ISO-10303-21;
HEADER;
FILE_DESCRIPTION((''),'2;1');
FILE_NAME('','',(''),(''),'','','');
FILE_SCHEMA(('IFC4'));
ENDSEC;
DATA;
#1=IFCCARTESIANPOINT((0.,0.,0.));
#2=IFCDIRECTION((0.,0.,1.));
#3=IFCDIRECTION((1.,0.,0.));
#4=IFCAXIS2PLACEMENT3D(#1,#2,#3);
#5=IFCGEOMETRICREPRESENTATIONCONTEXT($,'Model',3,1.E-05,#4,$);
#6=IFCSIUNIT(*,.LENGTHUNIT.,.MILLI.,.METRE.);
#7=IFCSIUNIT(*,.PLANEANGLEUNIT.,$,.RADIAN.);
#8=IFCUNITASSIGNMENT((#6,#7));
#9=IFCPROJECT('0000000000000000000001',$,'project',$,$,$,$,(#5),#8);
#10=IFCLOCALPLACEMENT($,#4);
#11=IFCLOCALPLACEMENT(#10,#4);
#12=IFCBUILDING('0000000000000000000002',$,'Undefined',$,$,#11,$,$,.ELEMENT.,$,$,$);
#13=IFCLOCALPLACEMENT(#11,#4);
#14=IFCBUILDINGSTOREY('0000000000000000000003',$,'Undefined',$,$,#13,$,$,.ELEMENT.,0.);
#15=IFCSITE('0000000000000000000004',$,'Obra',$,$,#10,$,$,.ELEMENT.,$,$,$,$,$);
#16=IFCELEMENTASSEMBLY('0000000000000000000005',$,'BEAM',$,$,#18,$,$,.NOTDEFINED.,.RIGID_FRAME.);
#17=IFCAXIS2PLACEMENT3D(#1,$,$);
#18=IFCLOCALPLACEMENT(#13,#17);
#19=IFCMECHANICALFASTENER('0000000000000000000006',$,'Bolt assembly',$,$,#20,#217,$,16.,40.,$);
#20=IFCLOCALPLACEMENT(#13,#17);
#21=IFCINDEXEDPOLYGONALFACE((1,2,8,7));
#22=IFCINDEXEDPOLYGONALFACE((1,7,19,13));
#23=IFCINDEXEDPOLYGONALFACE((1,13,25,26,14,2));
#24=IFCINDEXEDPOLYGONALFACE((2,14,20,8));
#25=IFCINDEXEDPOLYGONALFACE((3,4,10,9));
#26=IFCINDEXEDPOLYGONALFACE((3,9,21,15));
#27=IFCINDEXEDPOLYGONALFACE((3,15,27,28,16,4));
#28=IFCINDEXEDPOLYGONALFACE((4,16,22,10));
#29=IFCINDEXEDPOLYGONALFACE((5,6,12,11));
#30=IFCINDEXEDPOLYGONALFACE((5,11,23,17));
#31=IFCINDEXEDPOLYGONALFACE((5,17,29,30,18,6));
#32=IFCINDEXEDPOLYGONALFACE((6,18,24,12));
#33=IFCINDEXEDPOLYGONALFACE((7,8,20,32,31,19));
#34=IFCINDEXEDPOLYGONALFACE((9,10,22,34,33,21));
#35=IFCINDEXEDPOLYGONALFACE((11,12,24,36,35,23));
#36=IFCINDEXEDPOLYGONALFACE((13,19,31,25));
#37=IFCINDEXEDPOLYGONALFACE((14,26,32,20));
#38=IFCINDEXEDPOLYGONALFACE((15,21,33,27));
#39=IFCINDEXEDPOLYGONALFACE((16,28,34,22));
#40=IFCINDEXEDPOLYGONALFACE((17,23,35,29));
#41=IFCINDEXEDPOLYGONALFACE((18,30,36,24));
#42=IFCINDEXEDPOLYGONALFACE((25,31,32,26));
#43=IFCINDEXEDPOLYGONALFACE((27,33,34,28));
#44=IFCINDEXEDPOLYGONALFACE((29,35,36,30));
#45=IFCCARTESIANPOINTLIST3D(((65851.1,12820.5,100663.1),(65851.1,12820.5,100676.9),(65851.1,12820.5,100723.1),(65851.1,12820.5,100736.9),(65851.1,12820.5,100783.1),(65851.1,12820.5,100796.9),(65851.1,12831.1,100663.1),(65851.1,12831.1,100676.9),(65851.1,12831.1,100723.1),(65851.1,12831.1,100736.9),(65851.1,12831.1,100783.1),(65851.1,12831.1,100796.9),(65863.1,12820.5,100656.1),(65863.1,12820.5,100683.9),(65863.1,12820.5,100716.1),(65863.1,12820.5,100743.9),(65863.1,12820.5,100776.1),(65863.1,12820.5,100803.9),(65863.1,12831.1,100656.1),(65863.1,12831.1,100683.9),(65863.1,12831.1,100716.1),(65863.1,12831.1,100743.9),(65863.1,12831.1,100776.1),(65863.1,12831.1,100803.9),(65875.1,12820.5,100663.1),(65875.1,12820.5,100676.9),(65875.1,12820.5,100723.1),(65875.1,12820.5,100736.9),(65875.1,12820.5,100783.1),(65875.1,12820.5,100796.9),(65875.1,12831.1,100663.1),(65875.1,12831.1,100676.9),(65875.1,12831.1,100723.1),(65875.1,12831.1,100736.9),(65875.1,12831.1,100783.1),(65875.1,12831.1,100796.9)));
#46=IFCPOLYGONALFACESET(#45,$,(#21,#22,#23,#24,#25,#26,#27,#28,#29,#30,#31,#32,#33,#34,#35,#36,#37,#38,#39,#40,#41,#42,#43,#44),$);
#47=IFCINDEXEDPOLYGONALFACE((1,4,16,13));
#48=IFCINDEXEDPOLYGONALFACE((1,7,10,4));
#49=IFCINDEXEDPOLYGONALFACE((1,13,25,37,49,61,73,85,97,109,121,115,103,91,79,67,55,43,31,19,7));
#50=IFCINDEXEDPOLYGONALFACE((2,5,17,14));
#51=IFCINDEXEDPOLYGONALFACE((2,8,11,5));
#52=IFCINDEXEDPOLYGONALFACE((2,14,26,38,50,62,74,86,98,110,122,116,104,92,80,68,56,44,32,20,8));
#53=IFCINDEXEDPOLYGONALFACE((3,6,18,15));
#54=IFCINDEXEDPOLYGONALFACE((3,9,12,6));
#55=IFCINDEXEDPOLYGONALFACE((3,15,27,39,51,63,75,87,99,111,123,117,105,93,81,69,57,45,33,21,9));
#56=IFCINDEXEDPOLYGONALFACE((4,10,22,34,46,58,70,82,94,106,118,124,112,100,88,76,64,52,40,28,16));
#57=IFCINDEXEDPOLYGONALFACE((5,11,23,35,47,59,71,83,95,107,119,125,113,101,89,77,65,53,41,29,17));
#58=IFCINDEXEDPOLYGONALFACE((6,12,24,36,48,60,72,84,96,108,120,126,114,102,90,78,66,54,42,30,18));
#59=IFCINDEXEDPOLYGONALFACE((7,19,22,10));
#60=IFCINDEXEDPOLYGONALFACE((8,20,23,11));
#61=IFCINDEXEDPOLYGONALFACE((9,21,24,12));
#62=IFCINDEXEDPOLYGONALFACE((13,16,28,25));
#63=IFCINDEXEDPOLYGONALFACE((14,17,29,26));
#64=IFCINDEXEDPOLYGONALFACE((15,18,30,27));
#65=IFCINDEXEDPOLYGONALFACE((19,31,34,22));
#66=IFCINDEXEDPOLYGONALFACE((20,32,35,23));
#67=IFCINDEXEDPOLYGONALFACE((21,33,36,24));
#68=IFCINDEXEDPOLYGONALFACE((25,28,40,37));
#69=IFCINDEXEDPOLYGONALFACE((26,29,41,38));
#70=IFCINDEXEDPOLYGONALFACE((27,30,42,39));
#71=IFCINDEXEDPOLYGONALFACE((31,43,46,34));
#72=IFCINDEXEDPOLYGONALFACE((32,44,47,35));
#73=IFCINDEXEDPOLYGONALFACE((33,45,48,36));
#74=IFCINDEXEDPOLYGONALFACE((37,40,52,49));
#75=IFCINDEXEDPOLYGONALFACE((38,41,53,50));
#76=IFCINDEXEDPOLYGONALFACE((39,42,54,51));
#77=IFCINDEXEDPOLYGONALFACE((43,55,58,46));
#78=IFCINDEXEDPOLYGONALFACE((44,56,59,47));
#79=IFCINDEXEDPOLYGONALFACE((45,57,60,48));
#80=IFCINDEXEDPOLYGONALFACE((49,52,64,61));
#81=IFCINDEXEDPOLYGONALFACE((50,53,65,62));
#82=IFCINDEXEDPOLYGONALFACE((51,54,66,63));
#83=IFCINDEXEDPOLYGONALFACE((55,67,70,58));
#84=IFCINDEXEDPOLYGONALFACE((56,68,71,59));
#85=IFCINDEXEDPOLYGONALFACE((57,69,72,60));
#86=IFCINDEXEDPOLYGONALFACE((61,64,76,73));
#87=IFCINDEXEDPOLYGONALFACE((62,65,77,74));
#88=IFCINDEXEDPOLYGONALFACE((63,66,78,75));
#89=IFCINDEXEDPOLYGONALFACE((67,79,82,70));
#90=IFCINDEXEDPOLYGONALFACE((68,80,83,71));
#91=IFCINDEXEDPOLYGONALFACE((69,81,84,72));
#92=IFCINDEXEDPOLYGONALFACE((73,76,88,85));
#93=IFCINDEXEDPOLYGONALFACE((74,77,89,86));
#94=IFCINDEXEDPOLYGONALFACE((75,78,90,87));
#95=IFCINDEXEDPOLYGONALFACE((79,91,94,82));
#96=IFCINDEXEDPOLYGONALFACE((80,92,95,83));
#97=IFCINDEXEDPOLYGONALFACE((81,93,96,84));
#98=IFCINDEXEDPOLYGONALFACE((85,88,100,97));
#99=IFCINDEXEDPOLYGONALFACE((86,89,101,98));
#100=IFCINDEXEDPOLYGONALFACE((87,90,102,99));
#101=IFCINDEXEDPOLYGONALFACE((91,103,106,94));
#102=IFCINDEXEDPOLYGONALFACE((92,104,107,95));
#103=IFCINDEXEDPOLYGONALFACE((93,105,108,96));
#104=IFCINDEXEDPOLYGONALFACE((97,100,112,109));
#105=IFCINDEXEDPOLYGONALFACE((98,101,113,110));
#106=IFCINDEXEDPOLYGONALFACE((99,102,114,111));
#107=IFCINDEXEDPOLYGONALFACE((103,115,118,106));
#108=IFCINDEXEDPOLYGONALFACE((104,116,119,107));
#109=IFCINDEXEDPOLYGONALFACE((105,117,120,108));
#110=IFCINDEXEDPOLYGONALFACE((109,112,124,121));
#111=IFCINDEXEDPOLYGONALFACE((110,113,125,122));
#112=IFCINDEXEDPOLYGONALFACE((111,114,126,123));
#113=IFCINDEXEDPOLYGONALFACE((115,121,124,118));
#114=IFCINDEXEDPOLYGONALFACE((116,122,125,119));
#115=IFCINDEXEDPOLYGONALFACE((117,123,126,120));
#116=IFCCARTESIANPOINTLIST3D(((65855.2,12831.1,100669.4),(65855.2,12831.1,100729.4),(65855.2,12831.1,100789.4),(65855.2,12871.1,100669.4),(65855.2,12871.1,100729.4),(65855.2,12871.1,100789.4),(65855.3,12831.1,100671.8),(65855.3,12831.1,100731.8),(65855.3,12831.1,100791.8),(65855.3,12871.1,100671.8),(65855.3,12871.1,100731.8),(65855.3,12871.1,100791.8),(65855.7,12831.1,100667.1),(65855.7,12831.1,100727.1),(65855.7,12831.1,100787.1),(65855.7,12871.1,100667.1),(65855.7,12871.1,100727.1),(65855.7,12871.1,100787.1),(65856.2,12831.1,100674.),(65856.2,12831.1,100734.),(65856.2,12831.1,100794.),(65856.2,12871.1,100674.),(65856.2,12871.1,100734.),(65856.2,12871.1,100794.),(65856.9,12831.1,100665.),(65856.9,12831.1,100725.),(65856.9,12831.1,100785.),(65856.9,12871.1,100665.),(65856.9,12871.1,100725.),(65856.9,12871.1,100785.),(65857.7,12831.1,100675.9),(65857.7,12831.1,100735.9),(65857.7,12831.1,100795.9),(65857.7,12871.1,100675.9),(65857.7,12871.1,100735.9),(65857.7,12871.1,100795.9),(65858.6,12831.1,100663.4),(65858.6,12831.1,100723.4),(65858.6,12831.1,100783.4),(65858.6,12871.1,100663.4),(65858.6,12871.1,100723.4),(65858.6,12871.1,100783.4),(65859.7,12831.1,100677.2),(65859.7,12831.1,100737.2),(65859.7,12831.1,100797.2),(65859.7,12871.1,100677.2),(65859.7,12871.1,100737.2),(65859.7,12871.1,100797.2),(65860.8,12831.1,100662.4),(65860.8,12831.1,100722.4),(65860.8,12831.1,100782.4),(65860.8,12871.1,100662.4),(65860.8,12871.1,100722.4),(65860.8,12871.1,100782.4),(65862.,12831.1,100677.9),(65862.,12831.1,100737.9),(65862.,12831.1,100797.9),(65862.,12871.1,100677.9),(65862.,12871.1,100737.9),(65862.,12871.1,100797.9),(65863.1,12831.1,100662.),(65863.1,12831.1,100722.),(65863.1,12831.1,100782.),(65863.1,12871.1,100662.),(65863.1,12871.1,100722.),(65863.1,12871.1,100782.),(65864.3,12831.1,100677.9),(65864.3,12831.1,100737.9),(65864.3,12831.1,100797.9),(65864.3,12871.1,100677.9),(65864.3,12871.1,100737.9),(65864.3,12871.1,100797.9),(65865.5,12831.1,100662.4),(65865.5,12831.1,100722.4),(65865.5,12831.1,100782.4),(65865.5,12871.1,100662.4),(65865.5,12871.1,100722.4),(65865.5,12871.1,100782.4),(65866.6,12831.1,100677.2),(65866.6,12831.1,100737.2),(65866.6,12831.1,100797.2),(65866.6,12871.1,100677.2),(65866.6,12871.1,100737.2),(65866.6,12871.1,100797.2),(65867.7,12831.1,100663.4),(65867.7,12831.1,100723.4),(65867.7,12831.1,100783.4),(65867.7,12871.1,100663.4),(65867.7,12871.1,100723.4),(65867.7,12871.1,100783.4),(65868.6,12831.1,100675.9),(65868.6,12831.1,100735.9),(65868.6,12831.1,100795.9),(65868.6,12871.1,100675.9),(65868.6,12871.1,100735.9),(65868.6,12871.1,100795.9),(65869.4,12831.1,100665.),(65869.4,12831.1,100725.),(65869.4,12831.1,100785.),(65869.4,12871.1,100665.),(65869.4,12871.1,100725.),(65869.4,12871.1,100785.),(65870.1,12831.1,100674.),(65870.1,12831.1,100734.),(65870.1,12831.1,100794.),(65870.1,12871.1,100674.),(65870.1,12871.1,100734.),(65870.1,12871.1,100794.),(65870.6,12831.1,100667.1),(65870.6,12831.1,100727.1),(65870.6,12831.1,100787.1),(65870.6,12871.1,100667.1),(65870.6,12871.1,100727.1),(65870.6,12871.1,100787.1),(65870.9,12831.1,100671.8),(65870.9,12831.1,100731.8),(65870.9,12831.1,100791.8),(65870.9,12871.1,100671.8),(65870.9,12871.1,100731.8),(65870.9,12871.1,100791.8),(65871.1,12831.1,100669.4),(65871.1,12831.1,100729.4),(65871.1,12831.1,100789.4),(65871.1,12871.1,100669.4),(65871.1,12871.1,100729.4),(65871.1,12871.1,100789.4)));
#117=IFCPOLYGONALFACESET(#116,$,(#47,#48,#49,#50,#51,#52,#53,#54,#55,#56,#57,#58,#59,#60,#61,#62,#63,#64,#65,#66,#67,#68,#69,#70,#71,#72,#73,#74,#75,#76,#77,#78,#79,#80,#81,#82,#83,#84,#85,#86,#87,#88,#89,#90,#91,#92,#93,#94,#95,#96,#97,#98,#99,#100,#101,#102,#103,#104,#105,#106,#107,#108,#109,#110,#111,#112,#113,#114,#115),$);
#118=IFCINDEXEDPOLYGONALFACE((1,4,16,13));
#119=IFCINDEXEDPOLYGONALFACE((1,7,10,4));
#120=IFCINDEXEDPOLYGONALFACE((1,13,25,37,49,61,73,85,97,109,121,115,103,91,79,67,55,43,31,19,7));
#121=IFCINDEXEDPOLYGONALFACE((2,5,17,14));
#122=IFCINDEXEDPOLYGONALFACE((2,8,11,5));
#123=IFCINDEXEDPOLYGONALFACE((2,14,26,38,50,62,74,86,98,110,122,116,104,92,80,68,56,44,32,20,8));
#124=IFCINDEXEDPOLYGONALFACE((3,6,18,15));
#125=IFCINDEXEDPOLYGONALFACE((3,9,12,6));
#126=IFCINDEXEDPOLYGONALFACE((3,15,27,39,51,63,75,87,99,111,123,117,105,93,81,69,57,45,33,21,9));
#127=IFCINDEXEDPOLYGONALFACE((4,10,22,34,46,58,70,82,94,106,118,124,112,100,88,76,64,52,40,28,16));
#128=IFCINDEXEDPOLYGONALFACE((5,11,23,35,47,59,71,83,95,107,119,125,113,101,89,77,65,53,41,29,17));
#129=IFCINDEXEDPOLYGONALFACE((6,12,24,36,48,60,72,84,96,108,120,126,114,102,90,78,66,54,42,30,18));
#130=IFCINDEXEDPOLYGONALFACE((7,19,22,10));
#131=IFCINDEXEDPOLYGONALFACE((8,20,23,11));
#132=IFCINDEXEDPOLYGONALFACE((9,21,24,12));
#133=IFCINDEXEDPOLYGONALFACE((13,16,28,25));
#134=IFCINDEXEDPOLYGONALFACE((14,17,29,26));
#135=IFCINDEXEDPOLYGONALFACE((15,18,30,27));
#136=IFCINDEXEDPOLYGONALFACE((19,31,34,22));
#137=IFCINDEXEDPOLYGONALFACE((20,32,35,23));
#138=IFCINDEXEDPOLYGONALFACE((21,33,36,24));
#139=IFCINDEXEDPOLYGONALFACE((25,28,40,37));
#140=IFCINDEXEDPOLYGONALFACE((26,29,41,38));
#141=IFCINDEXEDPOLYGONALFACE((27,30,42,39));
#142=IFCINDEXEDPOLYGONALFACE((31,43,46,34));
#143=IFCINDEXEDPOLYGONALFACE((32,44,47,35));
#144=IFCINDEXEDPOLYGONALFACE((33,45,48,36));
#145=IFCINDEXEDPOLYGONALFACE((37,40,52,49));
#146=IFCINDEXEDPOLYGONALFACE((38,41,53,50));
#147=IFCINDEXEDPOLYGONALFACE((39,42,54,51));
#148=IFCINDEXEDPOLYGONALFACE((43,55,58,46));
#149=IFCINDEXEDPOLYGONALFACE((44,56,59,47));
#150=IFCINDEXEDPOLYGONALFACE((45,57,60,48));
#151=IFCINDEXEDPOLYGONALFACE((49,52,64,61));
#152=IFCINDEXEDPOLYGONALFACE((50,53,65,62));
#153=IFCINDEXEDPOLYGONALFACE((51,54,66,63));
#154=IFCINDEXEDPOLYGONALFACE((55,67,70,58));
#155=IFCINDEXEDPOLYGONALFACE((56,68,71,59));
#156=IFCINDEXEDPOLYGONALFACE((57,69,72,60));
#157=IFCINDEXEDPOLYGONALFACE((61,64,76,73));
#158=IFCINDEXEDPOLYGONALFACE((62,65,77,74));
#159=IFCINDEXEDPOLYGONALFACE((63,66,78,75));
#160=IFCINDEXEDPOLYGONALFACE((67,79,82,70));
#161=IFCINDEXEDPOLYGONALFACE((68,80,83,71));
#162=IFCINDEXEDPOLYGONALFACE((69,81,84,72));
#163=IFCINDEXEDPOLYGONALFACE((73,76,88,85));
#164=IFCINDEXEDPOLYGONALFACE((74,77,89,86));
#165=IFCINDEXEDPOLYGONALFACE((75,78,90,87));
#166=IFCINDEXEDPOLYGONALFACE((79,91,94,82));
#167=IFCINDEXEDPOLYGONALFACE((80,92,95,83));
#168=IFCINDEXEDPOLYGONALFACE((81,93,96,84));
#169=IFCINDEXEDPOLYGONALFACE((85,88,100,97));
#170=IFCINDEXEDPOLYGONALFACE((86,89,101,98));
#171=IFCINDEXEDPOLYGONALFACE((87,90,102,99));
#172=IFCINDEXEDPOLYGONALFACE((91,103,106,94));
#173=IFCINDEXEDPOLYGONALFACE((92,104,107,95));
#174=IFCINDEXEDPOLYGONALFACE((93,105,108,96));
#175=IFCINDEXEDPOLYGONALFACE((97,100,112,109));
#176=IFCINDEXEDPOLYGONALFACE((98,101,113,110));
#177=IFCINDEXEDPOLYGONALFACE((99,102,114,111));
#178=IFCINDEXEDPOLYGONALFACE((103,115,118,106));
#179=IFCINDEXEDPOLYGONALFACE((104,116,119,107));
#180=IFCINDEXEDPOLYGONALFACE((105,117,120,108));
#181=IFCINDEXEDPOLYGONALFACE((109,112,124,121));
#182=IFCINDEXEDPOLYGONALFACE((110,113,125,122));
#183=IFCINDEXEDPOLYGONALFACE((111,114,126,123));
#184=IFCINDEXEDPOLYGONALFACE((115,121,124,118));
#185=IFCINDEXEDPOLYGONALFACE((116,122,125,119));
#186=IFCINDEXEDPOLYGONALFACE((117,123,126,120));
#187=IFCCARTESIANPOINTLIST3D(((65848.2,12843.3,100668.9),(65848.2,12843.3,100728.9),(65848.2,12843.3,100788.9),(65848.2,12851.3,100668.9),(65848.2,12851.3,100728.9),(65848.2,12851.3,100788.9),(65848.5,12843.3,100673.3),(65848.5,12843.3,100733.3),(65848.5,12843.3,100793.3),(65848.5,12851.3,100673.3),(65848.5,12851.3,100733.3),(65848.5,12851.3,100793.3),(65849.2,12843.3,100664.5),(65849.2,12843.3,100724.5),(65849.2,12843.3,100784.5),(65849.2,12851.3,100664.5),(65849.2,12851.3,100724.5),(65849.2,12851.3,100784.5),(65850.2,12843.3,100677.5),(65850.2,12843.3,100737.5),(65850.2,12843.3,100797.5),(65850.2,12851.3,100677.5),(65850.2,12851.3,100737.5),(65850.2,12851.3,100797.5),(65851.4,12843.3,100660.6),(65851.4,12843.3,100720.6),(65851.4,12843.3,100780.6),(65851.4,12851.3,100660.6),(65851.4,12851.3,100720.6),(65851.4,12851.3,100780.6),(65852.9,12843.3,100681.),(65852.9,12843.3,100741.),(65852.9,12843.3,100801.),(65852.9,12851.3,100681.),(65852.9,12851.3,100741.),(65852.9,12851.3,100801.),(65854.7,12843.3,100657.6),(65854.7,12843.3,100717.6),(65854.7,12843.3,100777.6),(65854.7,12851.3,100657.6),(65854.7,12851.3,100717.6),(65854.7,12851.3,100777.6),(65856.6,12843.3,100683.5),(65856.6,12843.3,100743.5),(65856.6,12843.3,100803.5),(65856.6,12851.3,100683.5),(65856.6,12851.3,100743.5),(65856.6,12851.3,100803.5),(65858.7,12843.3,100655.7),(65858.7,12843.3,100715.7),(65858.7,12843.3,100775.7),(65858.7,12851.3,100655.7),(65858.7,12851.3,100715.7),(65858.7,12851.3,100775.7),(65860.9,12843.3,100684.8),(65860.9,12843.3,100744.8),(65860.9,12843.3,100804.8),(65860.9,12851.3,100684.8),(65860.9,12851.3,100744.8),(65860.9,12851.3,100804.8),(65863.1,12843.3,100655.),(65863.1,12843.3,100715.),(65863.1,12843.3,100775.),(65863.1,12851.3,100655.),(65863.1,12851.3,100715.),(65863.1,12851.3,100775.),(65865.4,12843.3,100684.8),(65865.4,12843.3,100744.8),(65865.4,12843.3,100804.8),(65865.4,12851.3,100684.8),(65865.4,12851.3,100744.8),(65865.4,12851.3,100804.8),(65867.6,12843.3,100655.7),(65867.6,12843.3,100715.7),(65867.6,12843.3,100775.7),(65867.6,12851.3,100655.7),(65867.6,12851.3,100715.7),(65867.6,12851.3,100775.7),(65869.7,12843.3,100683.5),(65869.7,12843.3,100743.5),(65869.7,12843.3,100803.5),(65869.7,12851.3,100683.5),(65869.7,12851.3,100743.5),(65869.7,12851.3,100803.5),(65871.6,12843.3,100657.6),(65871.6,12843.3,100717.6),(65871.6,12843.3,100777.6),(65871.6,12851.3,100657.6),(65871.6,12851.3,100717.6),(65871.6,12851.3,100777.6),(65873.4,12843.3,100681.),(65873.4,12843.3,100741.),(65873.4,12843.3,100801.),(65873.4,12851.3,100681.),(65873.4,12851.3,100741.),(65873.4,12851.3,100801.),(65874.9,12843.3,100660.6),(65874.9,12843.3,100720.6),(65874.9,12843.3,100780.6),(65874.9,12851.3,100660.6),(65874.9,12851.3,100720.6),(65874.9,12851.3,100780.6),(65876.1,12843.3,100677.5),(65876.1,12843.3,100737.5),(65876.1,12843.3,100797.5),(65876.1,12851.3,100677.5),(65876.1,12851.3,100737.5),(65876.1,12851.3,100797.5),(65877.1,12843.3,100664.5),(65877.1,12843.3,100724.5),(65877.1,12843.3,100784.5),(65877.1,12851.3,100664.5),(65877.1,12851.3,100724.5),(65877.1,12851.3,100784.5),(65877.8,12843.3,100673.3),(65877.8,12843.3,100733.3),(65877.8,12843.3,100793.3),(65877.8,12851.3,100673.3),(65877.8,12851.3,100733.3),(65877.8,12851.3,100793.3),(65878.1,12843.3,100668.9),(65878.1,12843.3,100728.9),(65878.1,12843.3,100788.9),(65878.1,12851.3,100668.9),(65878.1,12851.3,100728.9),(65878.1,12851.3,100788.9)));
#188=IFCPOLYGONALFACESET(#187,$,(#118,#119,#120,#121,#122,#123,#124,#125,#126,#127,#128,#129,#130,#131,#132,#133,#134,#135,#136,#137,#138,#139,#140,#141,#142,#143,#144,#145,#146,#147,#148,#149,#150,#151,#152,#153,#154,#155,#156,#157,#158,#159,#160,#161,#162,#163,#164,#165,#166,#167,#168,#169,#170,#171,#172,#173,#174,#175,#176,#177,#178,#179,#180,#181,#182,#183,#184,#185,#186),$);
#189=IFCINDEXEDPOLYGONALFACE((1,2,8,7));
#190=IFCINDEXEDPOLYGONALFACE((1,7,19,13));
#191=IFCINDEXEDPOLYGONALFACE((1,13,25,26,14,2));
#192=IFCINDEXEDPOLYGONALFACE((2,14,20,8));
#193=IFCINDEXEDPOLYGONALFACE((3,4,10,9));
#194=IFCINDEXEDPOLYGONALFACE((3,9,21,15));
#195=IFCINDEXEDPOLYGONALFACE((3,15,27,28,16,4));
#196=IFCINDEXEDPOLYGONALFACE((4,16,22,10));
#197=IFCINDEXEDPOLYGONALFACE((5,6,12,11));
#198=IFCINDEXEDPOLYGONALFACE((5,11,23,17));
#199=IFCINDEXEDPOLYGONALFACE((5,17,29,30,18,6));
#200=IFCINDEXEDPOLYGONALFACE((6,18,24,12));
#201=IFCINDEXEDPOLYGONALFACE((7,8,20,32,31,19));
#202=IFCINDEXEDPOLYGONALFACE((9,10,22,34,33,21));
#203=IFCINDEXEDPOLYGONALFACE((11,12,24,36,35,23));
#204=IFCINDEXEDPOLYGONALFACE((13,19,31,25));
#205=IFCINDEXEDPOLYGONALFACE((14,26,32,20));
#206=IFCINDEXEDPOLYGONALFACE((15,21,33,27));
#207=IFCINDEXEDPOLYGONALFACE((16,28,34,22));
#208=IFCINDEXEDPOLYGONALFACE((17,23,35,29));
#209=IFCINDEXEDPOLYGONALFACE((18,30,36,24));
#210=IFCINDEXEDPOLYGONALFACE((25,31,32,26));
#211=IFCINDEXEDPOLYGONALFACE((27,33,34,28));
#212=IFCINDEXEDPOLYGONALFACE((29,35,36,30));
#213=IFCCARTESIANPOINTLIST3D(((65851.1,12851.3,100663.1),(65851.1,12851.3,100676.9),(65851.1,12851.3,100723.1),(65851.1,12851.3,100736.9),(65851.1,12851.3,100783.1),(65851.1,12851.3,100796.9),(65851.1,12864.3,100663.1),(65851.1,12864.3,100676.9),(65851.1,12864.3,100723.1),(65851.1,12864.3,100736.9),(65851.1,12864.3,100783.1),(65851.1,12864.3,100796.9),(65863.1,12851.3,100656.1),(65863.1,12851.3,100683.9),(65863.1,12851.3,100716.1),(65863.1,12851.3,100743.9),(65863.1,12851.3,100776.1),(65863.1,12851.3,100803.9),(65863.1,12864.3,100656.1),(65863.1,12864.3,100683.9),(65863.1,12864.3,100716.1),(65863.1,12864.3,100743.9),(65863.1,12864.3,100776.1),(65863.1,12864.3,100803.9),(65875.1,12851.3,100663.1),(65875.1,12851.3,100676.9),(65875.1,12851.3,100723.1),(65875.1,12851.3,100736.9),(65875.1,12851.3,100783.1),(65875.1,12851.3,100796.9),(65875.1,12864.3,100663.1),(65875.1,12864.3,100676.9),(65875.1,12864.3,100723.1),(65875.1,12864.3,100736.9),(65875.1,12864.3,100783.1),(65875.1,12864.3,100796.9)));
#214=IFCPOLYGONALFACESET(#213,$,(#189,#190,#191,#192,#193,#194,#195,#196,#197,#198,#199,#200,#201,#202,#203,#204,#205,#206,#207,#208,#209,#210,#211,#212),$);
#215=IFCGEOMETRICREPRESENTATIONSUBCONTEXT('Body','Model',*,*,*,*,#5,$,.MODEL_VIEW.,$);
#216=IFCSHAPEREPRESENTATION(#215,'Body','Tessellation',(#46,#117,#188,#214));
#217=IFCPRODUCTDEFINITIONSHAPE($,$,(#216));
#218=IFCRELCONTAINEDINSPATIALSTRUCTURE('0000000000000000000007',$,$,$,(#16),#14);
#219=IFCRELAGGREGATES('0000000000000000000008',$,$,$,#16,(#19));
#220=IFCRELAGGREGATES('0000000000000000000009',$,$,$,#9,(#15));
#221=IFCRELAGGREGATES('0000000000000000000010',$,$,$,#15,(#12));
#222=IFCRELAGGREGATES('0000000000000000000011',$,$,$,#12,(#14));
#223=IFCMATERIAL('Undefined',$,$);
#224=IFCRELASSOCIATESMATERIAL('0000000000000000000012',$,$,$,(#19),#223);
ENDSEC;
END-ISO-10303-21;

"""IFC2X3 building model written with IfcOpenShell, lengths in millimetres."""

from ifc_helpers import new_model, si_unit, frame, origin_with_axes, origin_2d_with_axis, place, context, subcontext, project, spatial, polyline, circle, outline, extrude, source, transform, mapped, material, element, aggregate, save


model = new_model("IFC2X3")

# Units and contexts
model_context = context("Model", 3, precision=1e-05, world=origin_with_axes())
body_context = subcontext(model_context, "Body", "Model", "MODEL_VIEW")
ifc_project = project(units=[si_unit("LENGTHUNIT", "METRE", prefix="MILLI"), si_unit("PLANEANGLEUNIT", "RADIAN")], contexts=[model_context])

# Site, building, storey
site_placement = place(None, origin_with_axes())
site = spatial("IfcSite", under=ifc_project, at=site_placement, Name="Obra", CompositionType="ELEMENT")
building_placement = place(site_placement, origin_with_axes())
building = spatial("IfcBuilding", under=site, at=building_placement, Name="Undefined", CompositionType="ELEMENT")
storey_placement = place(building_placement, origin_with_axes())
storey = spatial("IfcBuildingStorey", under=building, at=storey_placement, Name="Undefined", CompositionType="ELEMENT", Elevation=0.0)

# Shared definitions
ifc_material_1 = material(Name="Undefined")

# Shared definitions
shared_shape_1 = source(origin_with_axes(), body_context, "Body", "SweptSolid", [
    extrude(outline(polyline([(13.9, 0.0), (6.9, 12.0), (-6.9, 12.0), (-13.9, 0.0), (-6.9, -12.0), (6.9, -12.0), (13.9, 0.0)])), frame((0.0, -19.7, 0.0), z_axis=(0.0, 1.0, 0.0), x_axis=(1.0, 0.0, 0.0)), (0.0, 0.0, 1.0), 10.6),
    extrude(circle(Radius=8.0, at=origin_2d_with_axis()), frame((0.0, -9.1, 0.0), z_axis=(0.0, 1.0, 0.0), x_axis=(1.0, 0.0, 0.0)), (0.0, 0.0, 1.0), 40.0),
    extrude(circle(Radius=15.0, at=origin_2d_with_axis()), frame((0.0, 3.1, 0.0), z_axis=(0.0, 1.0, 0.0), x_axis=(1.0, 0.0, 0.0)), (0.0, 0.0, 1.0), 8.0),
    extrude(outline(polyline([(13.9, 0.0), (6.9, 12.0), (-6.9, 12.0), (-13.9, 0.0), (-6.9, -12.0), (6.9, -12.0), (13.9, 0.0)])), frame((0.0, 11.1, 0.0), z_axis=(0.0, 1.0, 0.0), x_axis=(1.0, 0.0, 0.0)), (0.0, 0.0, 1.0), 13.0),
])

# Element assembly, mechanical fastener
assembly_1_placement = place(storey_placement, origin_with_axes())
assembly_1 = element("IfcElementAssembly", 1, at=assembly_1_placement, inside=storey, Name="BEAM", AssemblyPlace="NOTDEFINED", PredefinedType="RIGID_FRAME")
mechanical_fastener_1_placement = place(assembly_1_placement, frame((65813.1, 12840.2, 100850.0), z_axis=(1.0, 0.0, 0.0), x_axis=(0.0, 0.0, -1.0)))
mechanical_fastener_1 = element("IfcMechanicalFastener", 2, at=mechanical_fastener_1_placement, material=ifc_material_1, Name="Bolt assembly", NominalDiameter=16.0, NominalLength=40.0, context=body_context, shape_type="MappedRepresentation", body=[
    mapped(shared_shape_1, transform((60.0, 0.0, 50.0))),
    mapped(shared_shape_1, transform((120.0, 0.0, 50.0))),
    mapped(shared_shape_1, transform((180.0, 0.0, 50.0))),
])
aggregate(assembly_1, [mechanical_fastener_1])

save(model, "model.ifc")
